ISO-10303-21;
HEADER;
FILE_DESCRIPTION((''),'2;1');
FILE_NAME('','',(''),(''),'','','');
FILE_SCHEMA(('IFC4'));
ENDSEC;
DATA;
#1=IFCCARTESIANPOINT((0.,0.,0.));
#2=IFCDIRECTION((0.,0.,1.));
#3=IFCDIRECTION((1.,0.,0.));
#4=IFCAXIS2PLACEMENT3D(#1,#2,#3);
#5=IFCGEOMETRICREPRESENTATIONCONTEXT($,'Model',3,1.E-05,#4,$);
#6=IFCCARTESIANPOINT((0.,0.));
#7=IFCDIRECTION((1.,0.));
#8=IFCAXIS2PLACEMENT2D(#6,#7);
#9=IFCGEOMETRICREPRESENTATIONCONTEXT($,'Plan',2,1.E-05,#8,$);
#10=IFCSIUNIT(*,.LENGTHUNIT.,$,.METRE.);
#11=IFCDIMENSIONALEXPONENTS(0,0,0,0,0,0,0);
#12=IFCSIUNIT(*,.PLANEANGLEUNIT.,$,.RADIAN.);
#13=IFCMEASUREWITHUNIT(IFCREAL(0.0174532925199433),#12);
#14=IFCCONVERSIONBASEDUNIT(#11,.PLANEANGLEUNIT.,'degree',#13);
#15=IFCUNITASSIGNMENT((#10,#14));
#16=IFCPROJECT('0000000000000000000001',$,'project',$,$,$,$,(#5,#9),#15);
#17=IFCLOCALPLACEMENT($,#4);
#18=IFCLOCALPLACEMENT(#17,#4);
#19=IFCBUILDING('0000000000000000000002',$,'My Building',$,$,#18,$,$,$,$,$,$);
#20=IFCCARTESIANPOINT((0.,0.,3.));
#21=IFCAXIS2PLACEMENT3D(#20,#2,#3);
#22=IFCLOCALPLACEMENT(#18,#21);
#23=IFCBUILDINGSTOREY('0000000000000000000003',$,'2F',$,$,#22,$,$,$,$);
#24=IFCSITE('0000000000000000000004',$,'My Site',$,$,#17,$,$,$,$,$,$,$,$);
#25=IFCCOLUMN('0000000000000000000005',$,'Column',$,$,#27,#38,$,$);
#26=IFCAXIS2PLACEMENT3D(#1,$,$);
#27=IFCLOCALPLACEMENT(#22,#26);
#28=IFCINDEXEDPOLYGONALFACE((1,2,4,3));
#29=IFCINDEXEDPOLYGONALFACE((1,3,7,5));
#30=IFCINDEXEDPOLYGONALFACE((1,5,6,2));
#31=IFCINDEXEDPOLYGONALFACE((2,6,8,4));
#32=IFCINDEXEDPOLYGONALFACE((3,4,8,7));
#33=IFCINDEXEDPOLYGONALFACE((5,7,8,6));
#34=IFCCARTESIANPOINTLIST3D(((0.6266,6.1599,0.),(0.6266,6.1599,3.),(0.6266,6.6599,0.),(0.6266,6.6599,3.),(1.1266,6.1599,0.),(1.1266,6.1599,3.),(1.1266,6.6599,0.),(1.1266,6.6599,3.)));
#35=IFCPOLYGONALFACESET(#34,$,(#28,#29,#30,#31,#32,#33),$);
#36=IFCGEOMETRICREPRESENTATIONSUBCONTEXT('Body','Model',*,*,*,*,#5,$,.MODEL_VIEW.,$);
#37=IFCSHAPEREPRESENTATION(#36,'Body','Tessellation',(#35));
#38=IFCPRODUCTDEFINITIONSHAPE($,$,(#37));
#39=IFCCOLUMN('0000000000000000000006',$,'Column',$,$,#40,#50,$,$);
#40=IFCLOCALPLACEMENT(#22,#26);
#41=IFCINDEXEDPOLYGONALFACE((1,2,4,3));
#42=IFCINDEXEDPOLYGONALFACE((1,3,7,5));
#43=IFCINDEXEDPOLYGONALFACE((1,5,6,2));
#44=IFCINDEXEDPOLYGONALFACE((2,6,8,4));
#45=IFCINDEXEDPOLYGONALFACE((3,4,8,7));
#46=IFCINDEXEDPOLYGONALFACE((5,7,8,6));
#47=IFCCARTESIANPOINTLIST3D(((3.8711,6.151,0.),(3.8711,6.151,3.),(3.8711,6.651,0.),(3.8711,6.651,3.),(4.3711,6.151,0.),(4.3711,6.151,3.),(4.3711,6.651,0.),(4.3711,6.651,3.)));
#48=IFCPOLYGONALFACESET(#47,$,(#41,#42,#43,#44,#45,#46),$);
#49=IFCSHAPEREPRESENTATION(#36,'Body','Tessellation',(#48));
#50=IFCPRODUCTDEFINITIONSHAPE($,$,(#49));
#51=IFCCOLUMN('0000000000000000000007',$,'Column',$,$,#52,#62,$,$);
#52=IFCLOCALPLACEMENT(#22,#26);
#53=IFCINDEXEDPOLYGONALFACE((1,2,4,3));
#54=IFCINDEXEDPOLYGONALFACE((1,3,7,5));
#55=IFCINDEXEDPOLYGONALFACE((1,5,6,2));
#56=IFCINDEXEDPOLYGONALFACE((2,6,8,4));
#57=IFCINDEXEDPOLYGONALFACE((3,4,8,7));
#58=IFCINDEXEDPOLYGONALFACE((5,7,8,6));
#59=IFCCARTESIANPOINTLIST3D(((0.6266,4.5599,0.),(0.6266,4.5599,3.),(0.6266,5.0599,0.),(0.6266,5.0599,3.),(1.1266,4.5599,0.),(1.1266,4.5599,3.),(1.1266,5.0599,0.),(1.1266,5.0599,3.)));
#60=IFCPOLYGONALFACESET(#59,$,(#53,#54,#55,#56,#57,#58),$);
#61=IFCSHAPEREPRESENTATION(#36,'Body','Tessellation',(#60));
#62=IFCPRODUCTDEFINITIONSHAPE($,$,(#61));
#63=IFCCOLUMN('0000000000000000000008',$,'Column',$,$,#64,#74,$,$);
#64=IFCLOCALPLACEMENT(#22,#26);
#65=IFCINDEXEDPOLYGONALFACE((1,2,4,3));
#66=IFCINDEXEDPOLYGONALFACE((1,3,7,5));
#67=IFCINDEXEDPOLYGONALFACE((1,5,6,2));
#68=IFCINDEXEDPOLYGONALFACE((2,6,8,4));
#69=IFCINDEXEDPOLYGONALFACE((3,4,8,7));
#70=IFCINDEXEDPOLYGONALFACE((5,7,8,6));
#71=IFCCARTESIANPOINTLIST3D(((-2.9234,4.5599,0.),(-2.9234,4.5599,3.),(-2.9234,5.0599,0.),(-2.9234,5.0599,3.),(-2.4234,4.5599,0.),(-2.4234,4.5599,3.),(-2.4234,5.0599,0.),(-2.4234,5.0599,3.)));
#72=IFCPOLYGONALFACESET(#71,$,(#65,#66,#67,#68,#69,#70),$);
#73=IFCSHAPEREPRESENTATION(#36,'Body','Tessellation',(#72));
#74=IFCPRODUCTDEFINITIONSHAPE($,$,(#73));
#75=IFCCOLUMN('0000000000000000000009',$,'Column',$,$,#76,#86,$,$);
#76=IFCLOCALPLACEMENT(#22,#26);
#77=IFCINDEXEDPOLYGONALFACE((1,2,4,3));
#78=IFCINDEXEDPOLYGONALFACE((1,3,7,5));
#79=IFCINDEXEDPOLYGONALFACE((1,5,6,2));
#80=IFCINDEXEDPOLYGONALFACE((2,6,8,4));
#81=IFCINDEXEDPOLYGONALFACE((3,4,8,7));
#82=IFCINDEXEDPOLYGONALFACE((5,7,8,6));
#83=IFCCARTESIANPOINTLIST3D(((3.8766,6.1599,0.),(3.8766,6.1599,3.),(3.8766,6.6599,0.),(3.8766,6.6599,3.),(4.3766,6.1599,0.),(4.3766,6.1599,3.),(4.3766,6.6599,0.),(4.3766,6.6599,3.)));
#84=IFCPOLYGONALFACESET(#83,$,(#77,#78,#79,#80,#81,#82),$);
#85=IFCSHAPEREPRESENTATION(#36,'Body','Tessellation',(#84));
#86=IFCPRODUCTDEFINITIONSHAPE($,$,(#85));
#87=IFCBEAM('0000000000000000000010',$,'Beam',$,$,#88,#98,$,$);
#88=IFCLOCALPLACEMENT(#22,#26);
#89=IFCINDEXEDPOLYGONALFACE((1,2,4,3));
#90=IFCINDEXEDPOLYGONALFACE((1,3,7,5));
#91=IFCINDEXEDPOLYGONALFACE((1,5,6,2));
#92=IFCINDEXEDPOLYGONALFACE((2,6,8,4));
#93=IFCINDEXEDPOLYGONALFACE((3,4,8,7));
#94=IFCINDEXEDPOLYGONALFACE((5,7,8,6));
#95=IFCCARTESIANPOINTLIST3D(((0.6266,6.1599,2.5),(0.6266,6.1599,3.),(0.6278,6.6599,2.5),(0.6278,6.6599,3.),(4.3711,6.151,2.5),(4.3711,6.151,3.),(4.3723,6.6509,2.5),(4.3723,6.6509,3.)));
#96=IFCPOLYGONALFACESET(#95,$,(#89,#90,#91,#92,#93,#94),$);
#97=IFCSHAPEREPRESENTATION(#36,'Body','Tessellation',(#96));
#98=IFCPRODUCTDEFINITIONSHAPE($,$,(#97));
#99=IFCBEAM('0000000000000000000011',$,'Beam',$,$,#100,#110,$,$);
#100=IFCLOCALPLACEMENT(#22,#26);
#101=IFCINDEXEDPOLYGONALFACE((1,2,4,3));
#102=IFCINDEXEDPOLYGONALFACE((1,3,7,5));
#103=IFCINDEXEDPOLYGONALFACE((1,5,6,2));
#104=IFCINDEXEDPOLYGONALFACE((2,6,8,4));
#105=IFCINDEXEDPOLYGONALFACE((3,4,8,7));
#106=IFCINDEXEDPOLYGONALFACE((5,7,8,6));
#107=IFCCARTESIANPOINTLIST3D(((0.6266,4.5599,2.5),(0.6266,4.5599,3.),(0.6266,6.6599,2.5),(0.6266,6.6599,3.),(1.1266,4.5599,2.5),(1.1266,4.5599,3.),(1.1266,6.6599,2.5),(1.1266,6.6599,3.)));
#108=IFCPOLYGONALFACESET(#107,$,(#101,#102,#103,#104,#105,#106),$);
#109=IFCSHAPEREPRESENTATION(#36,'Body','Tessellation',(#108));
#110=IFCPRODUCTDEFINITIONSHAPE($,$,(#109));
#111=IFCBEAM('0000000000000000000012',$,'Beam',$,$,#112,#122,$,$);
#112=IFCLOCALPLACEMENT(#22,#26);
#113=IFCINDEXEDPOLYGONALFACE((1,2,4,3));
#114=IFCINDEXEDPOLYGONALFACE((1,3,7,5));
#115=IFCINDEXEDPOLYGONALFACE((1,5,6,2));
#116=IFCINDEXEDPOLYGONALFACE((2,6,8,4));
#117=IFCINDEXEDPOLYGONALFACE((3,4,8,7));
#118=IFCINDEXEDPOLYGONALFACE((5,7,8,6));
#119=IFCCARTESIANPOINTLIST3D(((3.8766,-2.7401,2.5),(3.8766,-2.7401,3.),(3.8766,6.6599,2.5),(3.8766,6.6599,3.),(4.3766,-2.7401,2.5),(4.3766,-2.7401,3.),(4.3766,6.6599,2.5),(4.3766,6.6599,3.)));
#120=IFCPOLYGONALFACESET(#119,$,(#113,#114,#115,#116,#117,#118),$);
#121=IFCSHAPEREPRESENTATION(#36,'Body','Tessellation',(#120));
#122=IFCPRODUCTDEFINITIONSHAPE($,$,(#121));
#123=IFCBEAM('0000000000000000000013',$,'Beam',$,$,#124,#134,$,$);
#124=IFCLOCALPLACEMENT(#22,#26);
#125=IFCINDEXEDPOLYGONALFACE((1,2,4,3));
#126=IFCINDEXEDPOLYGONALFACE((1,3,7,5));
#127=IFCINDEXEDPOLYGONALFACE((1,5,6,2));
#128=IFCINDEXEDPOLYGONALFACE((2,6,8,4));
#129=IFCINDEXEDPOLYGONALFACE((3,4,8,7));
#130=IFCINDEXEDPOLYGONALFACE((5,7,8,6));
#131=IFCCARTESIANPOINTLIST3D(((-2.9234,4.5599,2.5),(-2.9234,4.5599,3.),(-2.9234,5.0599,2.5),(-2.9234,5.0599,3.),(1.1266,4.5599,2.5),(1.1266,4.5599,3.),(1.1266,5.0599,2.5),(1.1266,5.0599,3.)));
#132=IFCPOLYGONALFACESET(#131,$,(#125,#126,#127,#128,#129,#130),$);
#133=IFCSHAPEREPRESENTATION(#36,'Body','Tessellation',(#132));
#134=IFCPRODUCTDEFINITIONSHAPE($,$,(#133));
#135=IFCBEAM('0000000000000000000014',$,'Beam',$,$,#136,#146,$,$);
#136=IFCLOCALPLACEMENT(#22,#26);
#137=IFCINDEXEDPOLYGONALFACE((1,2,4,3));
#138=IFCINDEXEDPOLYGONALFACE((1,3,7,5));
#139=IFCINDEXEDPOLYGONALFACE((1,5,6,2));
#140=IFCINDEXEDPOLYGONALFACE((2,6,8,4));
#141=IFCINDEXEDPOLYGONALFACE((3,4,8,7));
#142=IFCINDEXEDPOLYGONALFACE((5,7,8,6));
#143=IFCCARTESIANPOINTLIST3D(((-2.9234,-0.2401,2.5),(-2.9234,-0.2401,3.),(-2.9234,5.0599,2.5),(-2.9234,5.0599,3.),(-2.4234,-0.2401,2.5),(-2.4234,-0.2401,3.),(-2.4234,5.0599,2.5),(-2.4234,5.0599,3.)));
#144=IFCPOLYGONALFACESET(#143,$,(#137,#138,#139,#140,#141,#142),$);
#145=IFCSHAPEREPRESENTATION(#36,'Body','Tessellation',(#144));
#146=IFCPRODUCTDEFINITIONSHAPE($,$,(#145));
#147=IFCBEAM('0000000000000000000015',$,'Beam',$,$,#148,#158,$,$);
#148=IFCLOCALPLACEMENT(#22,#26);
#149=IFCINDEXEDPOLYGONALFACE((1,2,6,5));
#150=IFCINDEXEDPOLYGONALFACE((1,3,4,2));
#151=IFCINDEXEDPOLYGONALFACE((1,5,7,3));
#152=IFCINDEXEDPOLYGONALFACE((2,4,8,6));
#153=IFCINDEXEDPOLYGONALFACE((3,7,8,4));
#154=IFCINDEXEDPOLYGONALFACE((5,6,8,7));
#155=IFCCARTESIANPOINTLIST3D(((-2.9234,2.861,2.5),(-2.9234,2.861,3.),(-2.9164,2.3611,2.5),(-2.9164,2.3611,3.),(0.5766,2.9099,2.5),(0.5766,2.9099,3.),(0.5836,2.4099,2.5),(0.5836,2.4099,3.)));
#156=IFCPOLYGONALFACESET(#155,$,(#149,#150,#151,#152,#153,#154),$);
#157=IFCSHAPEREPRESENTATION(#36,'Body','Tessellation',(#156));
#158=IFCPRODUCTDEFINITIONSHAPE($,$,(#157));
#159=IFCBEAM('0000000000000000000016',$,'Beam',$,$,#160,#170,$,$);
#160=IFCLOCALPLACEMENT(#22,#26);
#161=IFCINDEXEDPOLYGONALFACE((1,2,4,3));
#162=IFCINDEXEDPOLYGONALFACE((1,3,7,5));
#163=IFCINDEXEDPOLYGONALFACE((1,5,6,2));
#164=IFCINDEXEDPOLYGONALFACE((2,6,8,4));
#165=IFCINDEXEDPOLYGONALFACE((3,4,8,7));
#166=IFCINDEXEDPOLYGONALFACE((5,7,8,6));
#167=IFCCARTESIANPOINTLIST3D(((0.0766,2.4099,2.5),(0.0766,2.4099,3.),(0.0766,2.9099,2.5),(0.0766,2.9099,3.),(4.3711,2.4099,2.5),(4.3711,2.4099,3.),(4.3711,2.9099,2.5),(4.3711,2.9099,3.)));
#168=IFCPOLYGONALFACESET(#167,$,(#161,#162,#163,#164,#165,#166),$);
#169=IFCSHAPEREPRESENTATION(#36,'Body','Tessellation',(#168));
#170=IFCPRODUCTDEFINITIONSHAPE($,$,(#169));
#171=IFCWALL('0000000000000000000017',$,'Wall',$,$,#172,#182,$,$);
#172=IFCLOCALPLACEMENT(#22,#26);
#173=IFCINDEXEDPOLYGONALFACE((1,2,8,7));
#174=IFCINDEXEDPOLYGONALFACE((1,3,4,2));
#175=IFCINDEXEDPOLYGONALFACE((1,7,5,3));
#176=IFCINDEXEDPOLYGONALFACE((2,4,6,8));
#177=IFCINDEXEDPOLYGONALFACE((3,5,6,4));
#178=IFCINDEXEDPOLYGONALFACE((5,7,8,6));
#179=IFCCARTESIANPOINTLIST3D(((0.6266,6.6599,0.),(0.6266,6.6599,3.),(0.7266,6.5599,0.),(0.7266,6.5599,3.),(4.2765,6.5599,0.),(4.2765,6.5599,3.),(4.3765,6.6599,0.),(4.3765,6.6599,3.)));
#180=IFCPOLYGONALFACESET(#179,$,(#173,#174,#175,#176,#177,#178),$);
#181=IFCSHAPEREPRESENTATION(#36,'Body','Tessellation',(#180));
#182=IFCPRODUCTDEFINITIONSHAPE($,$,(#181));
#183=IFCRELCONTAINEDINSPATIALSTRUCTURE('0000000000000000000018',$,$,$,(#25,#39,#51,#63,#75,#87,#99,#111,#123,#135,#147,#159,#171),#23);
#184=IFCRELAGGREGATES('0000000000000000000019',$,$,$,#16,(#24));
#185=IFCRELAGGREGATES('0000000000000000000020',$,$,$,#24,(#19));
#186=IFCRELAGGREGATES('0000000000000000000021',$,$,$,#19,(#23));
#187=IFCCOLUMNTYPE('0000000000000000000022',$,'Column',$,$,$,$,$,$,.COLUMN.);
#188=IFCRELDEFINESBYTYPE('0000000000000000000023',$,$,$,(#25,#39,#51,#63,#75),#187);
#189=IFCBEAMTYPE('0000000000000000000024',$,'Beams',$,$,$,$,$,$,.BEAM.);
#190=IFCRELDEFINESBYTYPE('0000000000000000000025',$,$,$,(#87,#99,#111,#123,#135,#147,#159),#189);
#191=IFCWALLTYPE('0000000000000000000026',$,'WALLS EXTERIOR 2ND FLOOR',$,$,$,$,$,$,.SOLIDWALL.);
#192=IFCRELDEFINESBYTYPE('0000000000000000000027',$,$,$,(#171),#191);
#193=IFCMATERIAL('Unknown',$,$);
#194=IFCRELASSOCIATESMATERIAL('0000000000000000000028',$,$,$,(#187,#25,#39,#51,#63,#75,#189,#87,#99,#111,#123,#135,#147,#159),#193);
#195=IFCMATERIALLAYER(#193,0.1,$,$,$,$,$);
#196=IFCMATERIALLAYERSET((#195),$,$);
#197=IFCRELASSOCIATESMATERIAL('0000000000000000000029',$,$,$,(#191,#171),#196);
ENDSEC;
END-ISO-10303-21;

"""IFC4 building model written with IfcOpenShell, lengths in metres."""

from ifc_helpers import new_model, entity, si_unit, converted_unit, frame, origin_with_axes, origin_2d_with_axis, place, context, subcontext, project, spatial, line, indexed_curve, rectangle, outline, extrude, material, layer, layer_set, layer_usage, material_profile, profile_set, profile_usage, type_object, element, save


model = new_model("IFC4")

# Units and contexts
model_context = context("Model", 3, precision=1e-05, world=origin_with_axes())
plan_context = context("Plan", 2, precision=1e-05, world=origin_2d_with_axis())
body_context_1 = subcontext(model_context, "Body", "Model", "MODEL_VIEW")
ifc_project = project(units=[si_unit("LENGTHUNIT", "METRE"), converted_unit("PLANEANGLEUNIT", "degree", entity("IfcReal", 0.0174532925199433), si_unit("PLANEANGLEUNIT", "RADIAN"), dimensions=[0, 0, 0, 0, 0, 0, 0])], contexts=[model_context, plan_context])

# Site, building, storey
site_placement = place(None, origin_with_axes())
site = spatial("IfcSite", under=ifc_project, at=site_placement, Name="My Site")
building_placement = place(site_placement, origin_with_axes())
building = spatial("IfcBuilding", under=site, at=building_placement, Name="My Building")
storey_placement = place(building_placement, frame((0.0, 0.0, 3.0), z_axis=(0.0, 0.0, 1.0), x_axis=(1.0, 0.0, 0.0)))
storey = spatial("IfcBuildingStorey", under=building, at=storey_placement, Name="2F")

# Columns
ifc_material = material(Name="Unknown")
ifc_material_profile_1 = material_profile(ifc_material, rectangle(XDim=0.5, YDim=0.5))
ifc_profile_set_1 = profile_set([ifc_material_profile_1])
ifc_profile_usage_1 = profile_usage(ifc_profile_set_1, cardinal=5)
column_type = type_object("IfcColumnType", Name="Column", PredefinedType="COLUMN", material=ifc_profile_set_1)
column_1_placement = place(storey_placement, frame((0.8766, 6.4099, 0.0), z_axis=(0.0, 0.0, 1.0), x_axis=(1.0, 0.0, 0.0)))
element("IfcColumn", 1, at=column_1_placement, inside=storey, type_object=column_type, material=ifc_profile_usage_1, Name="Column", context=body_context_1, shape_type="SweptSolid", body=[
    extrude(rectangle(XDim=0.5, YDim=0.5), origin_with_axes(), (0.0, 0.0, 1.0), 3.0),
])
ifc_profile_usage_2 = profile_usage(ifc_profile_set_1, cardinal=5)
column_2_placement = place(storey_placement, frame((4.1211, 6.401, 0.0), z_axis=(0.0, 0.0, 1.0), x_axis=(1.0, 0.0, 0.0)))
element("IfcColumn", 2, at=column_2_placement, inside=storey, type_object=column_type, material=ifc_profile_usage_2, Name="Column", context=body_context_1, shape_type="SweptSolid", body=[
    extrude(rectangle(XDim=0.5, YDim=0.5), origin_with_axes(), (0.0, 0.0, 1.0), 3.0),
])
ifc_profile_usage_3 = profile_usage(ifc_profile_set_1, cardinal=5)
column_3_placement = place(storey_placement, frame((0.8766, 4.8099, 0.0), z_axis=(0.0, 0.0, 1.0), x_axis=(1.0, 0.0, 0.0)))
element("IfcColumn", 3, at=column_3_placement, inside=storey, type_object=column_type, material=ifc_profile_usage_3, Name="Column", context=body_context_1, shape_type="SweptSolid", body=[
    extrude(rectangle(XDim=0.5, YDim=0.5), origin_with_axes(), (0.0, 0.0, 1.0), 3.0),
])
ifc_profile_usage_4 = profile_usage(ifc_profile_set_1, cardinal=5)
column_4_placement = place(storey_placement, frame((-2.6734, 4.8099, 0.0), z_axis=(0.0, 0.0, 1.0), x_axis=(1.0, 0.0, 0.0)))
element("IfcColumn", 4, at=column_4_placement, inside=storey, type_object=column_type, material=ifc_profile_usage_4, Name="Column", context=body_context_1, shape_type="SweptSolid", body=[
    extrude(rectangle(XDim=0.5, YDim=0.5), origin_with_axes(), (0.0, 0.0, 1.0), 3.0),
])
ifc_profile_usage_5 = profile_usage(ifc_profile_set_1, cardinal=5)
column_5_placement = place(storey_placement, frame((4.1266, 6.4099, 0.0), z_axis=(0.0, 0.0, 1.0), x_axis=(1.0, 0.0, 0.0)))
element("IfcColumn", 5, at=column_5_placement, inside=storey, type_object=column_type, material=ifc_profile_usage_5, Name="Column", context=body_context_1, shape_type="SweptSolid", body=[
    extrude(rectangle(XDim=0.5, YDim=0.5), origin_with_axes(), (0.0, 0.0, 1.0), 3.0),
])

# Beams
ifc_material_profile_2 = material_profile(ifc_material, rectangle(XDim=0.5, YDim=0.5))
ifc_profile_set_2 = profile_set([ifc_material_profile_2])
ifc_profile_usage_6 = profile_usage(ifc_profile_set_2, cardinal=7)
beam_type = type_object("IfcBeamType", Name="Beams", PredefinedType="BEAM", material=ifc_profile_set_2)
beam_1_placement = place(storey_placement, frame((4.3711, 6.151, 3.0), z_axis=(-0.999997, 0.002388, 0.0), x_axis=(-0.002388, -0.999997, 0.0)))
element("IfcBeam", 6, at=beam_1_placement, inside=storey, type_object=beam_type, material=ifc_profile_usage_6, Name="Beam", context=body_context_1, shape_type="SweptSolid", body=[
    extrude(rectangle(XDim=0.5, YDim=0.5), frame((-0.25, -0.25, 0.0), z_axis=(0.0, 0.0, 1.0), x_axis=(1.0, 0.0, 0.0)), (0.0, 0.0, 1.0), 3.7445),
])
ifc_profile_usage_7 = profile_usage(ifc_profile_set_2, cardinal=7)
beam_2_placement = place(storey_placement, frame((1.1266, 6.6599, 3.0), z_axis=(0.0, -1.0, 0.0), x_axis=(1.0, 0.0, 0.0)))
element("IfcBeam", 7, at=beam_2_placement, inside=storey, type_object=beam_type, material=ifc_profile_usage_7, Name="Beam", context=body_context_1, shape_type="SweptSolid", body=[
    extrude(rectangle(XDim=0.5, YDim=0.5), frame((-0.25, -0.25, 0.0), z_axis=(0.0, 0.0, 1.0), x_axis=(1.0, 0.0, 0.0)), (0.0, 0.0, 1.0), 2.1),
])
ifc_profile_usage_8 = profile_usage(ifc_profile_set_2, cardinal=7)
beam_3_placement = place(storey_placement, frame((4.3766, 6.6599, 3.0), z_axis=(0.0, -1.0, 0.0), x_axis=(1.0, 0.0, 0.0)))
element("IfcBeam", 8, at=beam_3_placement, inside=storey, type_object=beam_type, material=ifc_profile_usage_8, Name="Beam", context=body_context_1, shape_type="SweptSolid", body=[
    extrude(rectangle(XDim=0.5, YDim=0.5), frame((-0.25, -0.25, 0.0), z_axis=(0.0, 0.0, 1.0), x_axis=(1.0, 0.0, 0.0)), (0.0, 0.0, 1.0), 9.4),
])
ifc_profile_usage_9 = profile_usage(ifc_profile_set_2, cardinal=7)
beam_4_placement = place(storey_placement, frame((1.1266, 4.5599, 3.0), z_axis=(-1.0, -0.00001, 0.0), x_axis=(0.00001, -1.0, 0.0)))
element("IfcBeam", 9, at=beam_4_placement, inside=storey, type_object=beam_type, material=ifc_profile_usage_9, Name="Beam", context=body_context_1, shape_type="SweptSolid", body=[
    extrude(rectangle(XDim=0.5, YDim=0.5), frame((-0.25, -0.25, 0.0), z_axis=(0.0, 0.0, 1.0), x_axis=(1.0, 0.0, 0.0)), (0.0, 0.0, 1.0), 4.05),
])
ifc_profile_usage_10 = profile_usage(ifc_profile_set_2, cardinal=7)
beam_5_placement = place(storey_placement, frame((-2.4234, 5.0599, 3.0), z_axis=(0.000001, -1.0, 0.0), x_axis=(1.0, 0.000001, 0.0)))
element("IfcBeam", 10, at=beam_5_placement, inside=storey, type_object=beam_type, material=ifc_profile_usage_10, Name="Beam", context=body_context_1, shape_type="SweptSolid", body=[
    extrude(rectangle(XDim=0.5, YDim=0.5), frame((-0.25, -0.25, 0.0), z_axis=(0.0, 0.0, 1.0), x_axis=(1.0, 0.0, 0.0)), (0.0, 0.0, 1.0), 5.3),
])
ifc_profile_usage_11 = profile_usage(ifc_profile_set_2, cardinal=7)
beam_6_placement = place(storey_placement, frame((-2.9234, 2.861, 3.0), z_axis=(0.999902, 0.013964, 0.0), x_axis=(-0.013964, 0.999902, 0.0)))
element("IfcBeam", 11, at=beam_6_placement, inside=storey, type_object=beam_type, material=ifc_profile_usage_11, Name="Beam", context=body_context_1, shape_type="SweptSolid", body=[
    extrude(rectangle(XDim=0.5, YDim=0.5), frame((-0.25, -0.25, 0.0), z_axis=(0.0, 0.0, 1.0), x_axis=(1.0, 0.0, 0.0)), (0.0, 0.0, 1.0), 3.5004),
])
ifc_profile_usage_12 = profile_usage(ifc_profile_set_2, cardinal=7)
beam_7_placement = place(storey_placement, frame((0.0766, 2.9099, 3.0), z_axis=(1.0, 0.0, 0.0), x_axis=(0.0, 1.0, 0.0)))
element("IfcBeam", 12, at=beam_7_placement, inside=storey, type_object=beam_type, material=ifc_profile_usage_12, Name="Beam", context=body_context_1, shape_type="SweptSolid", body=[
    extrude(rectangle(XDim=0.5, YDim=0.5), frame((-0.25, -0.25, 0.0), z_axis=(0.0, 0.0, 1.0), x_axis=(1.0, 0.0, 0.0)), (0.0, 0.0, 1.0), 4.2945),
])

# Shared definitions
ifc_layer_1 = layer(ifc_material, 0.1)
ifc_layer_set_1 = layer_set([ifc_layer_1])
wall_type_1 = type_object("IfcWallType", Name="WALLS EXTERIOR 2ND FLOOR", PredefinedType="SOLIDWALL", material=ifc_layer_set_1)

# Wall
ifc_layer_usage_1 = layer_usage(ifc_layer_set_1, "AXIS2", "POSITIVE", 0.0)
wall_1_placement = place(storey_placement, frame((4.3765, 6.6599, 0.0), z_axis=(0.0, 0.0, 1.0), x_axis=(-1.0, 0.0, 0.0)))
element("IfcWall", 13, at=wall_1_placement, inside=storey, type_object=wall_type_1, material=ifc_layer_usage_1, Name="Wall", context=body_context_1, shape_type="SweptSolid", body=[
    extrude(outline(indexed_curve([(0.0, 0.0), (0.1, 0.1), (3.6499, 0.1), (3.7499, 0.0)], segments=[line(1, 2, 3, 4, 1)])), origin_with_axes(), (0.0, 0.0, 1.0), 3.0),
])

save(model, "model.ifc")
